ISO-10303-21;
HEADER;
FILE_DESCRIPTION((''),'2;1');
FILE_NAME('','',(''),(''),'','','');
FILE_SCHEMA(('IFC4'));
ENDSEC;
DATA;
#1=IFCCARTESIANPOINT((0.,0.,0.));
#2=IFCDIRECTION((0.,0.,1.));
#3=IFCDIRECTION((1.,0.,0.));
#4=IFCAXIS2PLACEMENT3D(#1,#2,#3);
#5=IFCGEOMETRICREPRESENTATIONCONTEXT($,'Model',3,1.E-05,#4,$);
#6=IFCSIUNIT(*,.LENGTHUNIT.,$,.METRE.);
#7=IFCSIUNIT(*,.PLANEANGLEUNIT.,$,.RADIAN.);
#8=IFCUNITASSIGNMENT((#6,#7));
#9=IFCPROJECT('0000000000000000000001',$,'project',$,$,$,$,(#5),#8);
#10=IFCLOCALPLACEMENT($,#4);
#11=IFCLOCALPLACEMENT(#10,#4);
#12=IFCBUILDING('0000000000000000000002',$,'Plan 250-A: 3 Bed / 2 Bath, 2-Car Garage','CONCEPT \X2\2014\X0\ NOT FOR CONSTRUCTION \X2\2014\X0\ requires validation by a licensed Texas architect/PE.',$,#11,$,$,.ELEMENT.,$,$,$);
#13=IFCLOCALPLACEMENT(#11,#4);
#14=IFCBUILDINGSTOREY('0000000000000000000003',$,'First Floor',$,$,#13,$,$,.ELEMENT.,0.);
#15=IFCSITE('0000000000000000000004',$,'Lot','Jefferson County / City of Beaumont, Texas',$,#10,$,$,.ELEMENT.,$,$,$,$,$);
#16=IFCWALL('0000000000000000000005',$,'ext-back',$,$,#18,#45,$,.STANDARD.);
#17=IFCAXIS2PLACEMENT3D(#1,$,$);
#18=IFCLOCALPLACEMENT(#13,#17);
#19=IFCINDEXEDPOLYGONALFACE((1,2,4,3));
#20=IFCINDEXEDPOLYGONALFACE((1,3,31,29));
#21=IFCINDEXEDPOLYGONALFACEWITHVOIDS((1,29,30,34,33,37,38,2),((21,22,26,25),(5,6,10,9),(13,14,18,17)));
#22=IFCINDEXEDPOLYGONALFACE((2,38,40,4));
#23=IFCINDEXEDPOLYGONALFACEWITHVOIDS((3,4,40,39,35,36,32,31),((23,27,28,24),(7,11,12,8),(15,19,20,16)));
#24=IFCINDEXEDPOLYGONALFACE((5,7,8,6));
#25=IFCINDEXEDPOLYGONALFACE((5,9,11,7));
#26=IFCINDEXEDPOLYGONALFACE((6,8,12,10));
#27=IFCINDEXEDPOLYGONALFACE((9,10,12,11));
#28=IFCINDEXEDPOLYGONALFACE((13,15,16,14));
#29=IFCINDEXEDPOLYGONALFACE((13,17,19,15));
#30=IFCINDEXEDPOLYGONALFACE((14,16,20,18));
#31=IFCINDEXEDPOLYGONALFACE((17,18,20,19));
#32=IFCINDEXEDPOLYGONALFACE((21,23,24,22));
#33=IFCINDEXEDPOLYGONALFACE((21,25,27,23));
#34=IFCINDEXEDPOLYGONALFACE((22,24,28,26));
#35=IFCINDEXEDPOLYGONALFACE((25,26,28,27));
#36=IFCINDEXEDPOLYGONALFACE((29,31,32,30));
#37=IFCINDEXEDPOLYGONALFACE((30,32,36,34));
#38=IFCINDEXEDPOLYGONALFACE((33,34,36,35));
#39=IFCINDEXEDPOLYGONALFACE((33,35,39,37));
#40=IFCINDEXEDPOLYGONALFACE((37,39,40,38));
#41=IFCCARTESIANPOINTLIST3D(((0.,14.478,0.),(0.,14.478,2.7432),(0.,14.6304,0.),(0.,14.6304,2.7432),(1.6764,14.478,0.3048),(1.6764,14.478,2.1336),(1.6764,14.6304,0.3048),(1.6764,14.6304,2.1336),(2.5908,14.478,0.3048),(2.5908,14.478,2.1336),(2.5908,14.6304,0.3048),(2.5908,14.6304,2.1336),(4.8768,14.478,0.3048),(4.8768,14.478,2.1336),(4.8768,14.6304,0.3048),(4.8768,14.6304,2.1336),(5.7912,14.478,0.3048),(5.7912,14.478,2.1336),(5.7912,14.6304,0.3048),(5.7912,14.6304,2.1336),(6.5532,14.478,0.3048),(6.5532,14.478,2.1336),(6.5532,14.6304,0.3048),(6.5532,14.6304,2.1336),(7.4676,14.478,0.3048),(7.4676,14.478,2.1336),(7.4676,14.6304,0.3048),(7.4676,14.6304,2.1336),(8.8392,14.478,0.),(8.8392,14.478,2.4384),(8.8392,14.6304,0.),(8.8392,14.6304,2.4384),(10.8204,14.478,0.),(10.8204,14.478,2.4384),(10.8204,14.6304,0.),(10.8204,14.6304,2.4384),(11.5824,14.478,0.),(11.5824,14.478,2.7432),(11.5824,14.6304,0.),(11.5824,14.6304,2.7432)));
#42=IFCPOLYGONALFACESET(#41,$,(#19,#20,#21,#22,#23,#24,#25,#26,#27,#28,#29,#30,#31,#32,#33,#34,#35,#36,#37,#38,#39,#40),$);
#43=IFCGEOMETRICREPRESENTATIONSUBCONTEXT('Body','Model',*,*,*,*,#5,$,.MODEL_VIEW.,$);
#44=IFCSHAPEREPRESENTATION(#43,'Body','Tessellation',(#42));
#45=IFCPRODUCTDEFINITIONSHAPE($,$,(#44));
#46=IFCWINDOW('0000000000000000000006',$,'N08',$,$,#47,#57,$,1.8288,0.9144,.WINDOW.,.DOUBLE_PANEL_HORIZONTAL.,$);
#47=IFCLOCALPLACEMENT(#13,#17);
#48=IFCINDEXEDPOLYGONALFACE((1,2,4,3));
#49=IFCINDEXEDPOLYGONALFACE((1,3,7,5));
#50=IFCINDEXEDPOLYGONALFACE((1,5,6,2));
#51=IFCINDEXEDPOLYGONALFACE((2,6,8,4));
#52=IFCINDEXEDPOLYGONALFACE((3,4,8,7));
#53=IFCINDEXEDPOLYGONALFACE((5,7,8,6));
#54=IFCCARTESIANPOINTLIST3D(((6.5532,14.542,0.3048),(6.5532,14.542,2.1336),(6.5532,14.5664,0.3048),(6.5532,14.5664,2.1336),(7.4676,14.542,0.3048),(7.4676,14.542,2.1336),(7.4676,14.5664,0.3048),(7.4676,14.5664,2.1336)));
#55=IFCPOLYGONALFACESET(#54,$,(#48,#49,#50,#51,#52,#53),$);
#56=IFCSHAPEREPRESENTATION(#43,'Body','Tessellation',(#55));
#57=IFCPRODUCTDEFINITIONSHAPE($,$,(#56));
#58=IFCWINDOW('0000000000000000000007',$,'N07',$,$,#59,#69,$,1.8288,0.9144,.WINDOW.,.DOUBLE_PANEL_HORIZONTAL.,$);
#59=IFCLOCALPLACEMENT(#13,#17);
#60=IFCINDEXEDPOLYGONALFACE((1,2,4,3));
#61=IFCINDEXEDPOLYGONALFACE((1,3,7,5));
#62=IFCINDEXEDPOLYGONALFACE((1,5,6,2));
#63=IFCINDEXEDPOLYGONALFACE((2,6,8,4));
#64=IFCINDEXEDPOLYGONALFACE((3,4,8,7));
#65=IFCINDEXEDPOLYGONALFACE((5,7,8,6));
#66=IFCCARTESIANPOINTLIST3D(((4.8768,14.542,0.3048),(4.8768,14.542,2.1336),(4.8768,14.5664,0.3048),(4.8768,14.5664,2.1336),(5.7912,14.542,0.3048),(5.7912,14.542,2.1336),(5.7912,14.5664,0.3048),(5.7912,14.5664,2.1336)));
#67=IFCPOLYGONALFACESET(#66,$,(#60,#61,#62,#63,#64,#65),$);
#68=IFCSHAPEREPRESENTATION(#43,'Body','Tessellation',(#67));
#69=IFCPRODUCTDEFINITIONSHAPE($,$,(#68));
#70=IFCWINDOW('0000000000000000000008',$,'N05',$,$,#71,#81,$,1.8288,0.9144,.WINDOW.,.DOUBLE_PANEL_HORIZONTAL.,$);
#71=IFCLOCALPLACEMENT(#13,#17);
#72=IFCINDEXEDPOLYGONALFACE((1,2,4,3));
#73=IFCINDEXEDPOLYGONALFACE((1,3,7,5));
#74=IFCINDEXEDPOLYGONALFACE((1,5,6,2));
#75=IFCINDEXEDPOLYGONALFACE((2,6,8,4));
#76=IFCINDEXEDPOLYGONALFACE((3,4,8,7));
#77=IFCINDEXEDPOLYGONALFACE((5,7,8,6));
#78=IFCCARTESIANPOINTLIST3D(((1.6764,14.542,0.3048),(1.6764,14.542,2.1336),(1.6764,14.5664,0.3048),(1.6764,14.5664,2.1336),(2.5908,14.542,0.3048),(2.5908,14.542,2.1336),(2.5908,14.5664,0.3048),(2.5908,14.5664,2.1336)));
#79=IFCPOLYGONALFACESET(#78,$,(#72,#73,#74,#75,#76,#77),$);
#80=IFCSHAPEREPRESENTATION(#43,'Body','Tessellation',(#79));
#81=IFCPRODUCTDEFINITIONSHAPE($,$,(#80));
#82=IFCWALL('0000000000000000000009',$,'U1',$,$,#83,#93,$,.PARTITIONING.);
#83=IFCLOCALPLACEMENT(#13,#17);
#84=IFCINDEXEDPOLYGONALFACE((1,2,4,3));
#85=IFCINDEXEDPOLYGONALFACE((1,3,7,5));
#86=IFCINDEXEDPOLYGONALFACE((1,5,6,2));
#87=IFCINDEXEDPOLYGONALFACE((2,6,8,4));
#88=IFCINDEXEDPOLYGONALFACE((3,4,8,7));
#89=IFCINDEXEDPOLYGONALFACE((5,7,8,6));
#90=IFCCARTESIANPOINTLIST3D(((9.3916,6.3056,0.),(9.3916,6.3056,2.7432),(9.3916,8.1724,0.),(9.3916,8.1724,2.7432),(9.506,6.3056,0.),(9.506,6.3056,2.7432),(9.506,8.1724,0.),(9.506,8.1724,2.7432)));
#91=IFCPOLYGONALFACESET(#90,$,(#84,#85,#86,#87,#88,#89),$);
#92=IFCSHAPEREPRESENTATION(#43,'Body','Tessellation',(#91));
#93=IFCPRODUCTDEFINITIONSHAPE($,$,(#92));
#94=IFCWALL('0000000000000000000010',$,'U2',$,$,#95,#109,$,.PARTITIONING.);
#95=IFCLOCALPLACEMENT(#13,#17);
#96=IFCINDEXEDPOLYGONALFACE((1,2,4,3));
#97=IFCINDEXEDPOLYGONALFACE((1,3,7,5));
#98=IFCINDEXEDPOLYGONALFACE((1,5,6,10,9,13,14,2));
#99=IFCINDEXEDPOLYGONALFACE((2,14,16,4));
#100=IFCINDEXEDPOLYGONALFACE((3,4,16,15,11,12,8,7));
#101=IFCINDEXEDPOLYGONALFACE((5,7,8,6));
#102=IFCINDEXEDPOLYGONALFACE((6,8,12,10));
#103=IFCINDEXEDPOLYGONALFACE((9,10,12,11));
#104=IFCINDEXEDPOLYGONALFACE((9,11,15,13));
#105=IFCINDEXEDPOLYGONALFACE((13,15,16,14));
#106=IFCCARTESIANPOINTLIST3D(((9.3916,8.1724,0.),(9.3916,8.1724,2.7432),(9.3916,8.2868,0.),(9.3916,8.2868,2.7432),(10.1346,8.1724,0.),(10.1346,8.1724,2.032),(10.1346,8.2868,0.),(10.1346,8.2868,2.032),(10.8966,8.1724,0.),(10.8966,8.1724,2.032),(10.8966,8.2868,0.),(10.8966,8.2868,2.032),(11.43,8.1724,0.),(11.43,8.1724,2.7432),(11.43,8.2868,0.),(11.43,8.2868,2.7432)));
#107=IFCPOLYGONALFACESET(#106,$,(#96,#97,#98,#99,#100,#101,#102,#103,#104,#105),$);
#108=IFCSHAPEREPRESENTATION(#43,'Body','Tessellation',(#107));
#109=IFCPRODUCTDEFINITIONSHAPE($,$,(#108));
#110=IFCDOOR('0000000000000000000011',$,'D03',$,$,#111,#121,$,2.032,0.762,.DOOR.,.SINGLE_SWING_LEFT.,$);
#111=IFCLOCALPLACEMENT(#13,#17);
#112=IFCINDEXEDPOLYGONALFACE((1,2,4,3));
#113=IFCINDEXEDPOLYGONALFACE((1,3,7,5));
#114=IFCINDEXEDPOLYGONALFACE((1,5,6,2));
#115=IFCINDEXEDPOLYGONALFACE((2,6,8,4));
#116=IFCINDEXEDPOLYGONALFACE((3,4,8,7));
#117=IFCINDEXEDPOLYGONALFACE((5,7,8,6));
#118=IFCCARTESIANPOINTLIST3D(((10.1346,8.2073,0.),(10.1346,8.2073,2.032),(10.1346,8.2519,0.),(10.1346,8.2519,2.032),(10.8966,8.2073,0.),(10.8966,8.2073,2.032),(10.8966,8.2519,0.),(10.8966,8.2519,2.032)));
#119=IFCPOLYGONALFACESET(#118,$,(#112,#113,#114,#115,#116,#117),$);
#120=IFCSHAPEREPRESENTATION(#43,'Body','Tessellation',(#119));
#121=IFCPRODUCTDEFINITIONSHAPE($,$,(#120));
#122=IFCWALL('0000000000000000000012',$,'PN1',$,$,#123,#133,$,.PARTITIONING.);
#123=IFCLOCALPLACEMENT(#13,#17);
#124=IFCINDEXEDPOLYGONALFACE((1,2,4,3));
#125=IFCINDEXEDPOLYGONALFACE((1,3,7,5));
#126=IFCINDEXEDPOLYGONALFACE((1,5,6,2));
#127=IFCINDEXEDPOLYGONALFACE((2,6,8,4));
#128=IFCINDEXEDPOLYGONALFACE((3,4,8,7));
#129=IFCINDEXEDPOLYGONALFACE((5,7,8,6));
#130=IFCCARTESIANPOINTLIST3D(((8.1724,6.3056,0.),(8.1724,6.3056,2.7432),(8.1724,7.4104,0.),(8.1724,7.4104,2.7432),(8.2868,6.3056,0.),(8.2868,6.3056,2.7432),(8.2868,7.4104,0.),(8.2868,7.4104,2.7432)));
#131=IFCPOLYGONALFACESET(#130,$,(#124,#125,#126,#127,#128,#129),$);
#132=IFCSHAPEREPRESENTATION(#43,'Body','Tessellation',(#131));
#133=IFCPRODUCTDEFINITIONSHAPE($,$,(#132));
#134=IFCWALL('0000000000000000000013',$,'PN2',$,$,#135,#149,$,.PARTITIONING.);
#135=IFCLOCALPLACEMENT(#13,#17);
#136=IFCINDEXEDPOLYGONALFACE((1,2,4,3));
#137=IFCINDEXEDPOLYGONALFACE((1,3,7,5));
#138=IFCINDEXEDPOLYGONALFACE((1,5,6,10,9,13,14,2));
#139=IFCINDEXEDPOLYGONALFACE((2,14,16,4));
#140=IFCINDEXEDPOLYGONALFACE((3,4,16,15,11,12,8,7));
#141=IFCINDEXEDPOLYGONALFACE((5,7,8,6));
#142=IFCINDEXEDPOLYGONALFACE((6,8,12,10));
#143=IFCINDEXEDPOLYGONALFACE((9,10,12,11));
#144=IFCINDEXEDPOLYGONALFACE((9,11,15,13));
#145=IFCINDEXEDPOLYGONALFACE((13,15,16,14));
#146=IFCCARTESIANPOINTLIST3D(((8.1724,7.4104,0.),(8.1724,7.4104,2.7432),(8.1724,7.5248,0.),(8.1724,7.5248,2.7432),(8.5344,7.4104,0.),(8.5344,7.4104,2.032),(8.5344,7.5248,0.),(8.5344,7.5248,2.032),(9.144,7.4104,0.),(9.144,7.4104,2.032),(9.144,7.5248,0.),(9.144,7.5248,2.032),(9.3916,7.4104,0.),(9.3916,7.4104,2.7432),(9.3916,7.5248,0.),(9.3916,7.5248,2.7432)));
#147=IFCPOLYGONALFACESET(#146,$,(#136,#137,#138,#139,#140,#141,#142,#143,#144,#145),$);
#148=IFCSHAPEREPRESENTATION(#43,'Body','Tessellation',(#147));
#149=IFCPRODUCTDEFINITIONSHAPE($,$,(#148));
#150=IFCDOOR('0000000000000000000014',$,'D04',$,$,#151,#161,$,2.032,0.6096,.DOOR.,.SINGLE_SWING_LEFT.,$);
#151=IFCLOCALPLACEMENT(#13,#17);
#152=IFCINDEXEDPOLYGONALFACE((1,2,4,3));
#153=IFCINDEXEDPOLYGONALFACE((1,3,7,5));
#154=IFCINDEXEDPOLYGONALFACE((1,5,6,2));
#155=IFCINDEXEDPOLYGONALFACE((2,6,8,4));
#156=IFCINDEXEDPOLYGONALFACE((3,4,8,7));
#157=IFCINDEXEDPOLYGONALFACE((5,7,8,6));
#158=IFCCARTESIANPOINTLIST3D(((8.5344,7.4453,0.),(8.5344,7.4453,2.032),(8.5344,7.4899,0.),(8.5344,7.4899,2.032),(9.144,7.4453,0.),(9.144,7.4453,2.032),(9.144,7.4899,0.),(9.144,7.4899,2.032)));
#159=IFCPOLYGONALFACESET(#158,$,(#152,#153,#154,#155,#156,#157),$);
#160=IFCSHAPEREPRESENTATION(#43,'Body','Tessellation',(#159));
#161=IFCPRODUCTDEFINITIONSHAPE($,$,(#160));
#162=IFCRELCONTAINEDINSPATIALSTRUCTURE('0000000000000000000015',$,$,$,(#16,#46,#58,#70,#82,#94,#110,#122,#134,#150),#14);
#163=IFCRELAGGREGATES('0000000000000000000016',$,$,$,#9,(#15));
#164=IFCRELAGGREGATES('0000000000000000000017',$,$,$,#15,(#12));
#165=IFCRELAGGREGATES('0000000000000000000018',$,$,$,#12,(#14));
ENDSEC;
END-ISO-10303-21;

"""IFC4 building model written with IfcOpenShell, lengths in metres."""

from ifc_helpers import new_model, si_unit, frame, frame_2d, origin_with_axes, place, context, subcontext, project, spatial, rectangle, extrude, element, fill, save


model = new_model("IFC4")

# Units and contexts
model_context = context("Model", 3, precision=1e-05, world=origin_with_axes())
body_context = subcontext(model_context, "Body", "Model", "MODEL_VIEW")
ifc_project = project(units=[si_unit("LENGTHUNIT", "METRE"), si_unit("PLANEANGLEUNIT", "RADIAN")], contexts=[model_context])

# Site, building, storey
site_placement = place(None, origin_with_axes())
site = spatial("IfcSite", under=ifc_project, at=site_placement, Name="Lot", Description="Jefferson County / City of Beaumont, Texas", CompositionType="ELEMENT")
building_placement = place(site_placement, origin_with_axes())
building = spatial("IfcBuilding", under=site, at=building_placement, Name="Plan 250-A: 3 Bed / 2 Bath, 2-Car Garage", Description="CONCEPT — NOT FOR CONSTRUCTION — requires validation by a licensed Texas architect/PE.", CompositionType="ELEMENT")
storey_placement = place(building_placement, origin_with_axes())
storey = spatial("IfcBuildingStorey", under=building, at=storey_placement, Name="First Floor", CompositionType="ELEMENT", Elevation=0.0)

# Wall, openings, windows
wall_1_placement = place(storey_placement, frame((11.5824, 14.5542, 0.0), z_axis=(0.0, 0.0, 1.0), x_axis=(-1.0, 0.0, 0.0)))
wall_1 = element("IfcWall", 1, at=wall_1_placement, inside=storey, Name="ext-back", PredefinedType="STANDARD", context=body_context, shape_type="SweptSolid", body=[
    extrude(rectangle(XDim=11.5824, YDim=0.1524, at=frame_2d((5.7912, 0.0), x_axis=(1.0, 0.0))), origin_with_axes(), (0.0, 0.0, 1.0), 2.7432),
])
opening_1_placement = place(wall_1_placement, frame((0.762, 0.0, 0.0), z_axis=(0.0, 0.0, 1.0), x_axis=(1.0, 0.0, 0.0)))
element("IfcOpeningElement", 2, at=opening_1_placement, cuts=wall_1, PredefinedType="OPENING", context=body_context, shape_type="SweptSolid", body=[
    extrude(rectangle(XDim=1.9812, YDim=0.1829, at=frame_2d((0.9906, 0.0), x_axis=(1.0, 0.0))), origin_with_axes(), (0.0, 0.0, 1.0), 2.4384),
])
opening_2_placement = place(wall_1_placement, frame((4.1148, 0.0, 0.3048), z_axis=(0.0, 0.0, 1.0), x_axis=(1.0, 0.0, 0.0)))
opening_2 = element("IfcOpeningElement", 3, at=opening_2_placement, cuts=wall_1, PredefinedType="OPENING", context=body_context, shape_type="SweptSolid", body=[
    extrude(rectangle(XDim=0.9144, YDim=0.1829, at=frame_2d((0.4572, 0.0), x_axis=(1.0, 0.0))), origin_with_axes(), (0.0, 0.0, 1.0), 1.8288),
])
opening_3_placement = place(wall_1_placement, frame((5.7912, 0.0, 0.3048), z_axis=(0.0, 0.0, 1.0), x_axis=(1.0, 0.0, 0.0)))
opening_3 = element("IfcOpeningElement", 4, at=opening_3_placement, cuts=wall_1, PredefinedType="OPENING", context=body_context, shape_type="SweptSolid", body=[
    extrude(rectangle(XDim=0.9144, YDim=0.1829, at=frame_2d((0.4572, 0.0), x_axis=(1.0, 0.0))), origin_with_axes(), (0.0, 0.0, 1.0), 1.8288),
])
opening_4_placement = place(wall_1_placement, frame((8.9916, 0.0, 0.3048), z_axis=(0.0, 0.0, 1.0), x_axis=(1.0, 0.0, 0.0)))
opening_4 = element("IfcOpeningElement", 5, at=opening_4_placement, cuts=wall_1, PredefinedType="OPENING", context=body_context, shape_type="SweptSolid", body=[
    extrude(rectangle(XDim=0.9144, YDim=0.1829, at=frame_2d((0.4572, 0.0), x_axis=(1.0, 0.0))), origin_with_axes(), (0.0, 0.0, 1.0), 1.8288),
])
window_1_placement = place(opening_2_placement, origin_with_axes())
window_1 = element("IfcWindow", 6, at=window_1_placement, inside=storey, Name="N08", OverallHeight=1.8288, OverallWidth=0.9144, PartitioningType="DOUBLE_PANEL_HORIZONTAL", PredefinedType="WINDOW", context=body_context, shape_type="SweptSolid", body=[
    extrude(rectangle(XDim=0.9144, YDim=0.0244, at=frame_2d((0.4572, 0.0), x_axis=(1.0, 0.0))), origin_with_axes(), (0.0, 0.0, 1.0), 1.8288),
])
fill(opening_2, window_1)
window_2_placement = place(opening_3_placement, origin_with_axes())
window_2 = element("IfcWindow", 7, at=window_2_placement, inside=storey, Name="N07", OverallHeight=1.8288, OverallWidth=0.9144, PartitioningType="DOUBLE_PANEL_HORIZONTAL", PredefinedType="WINDOW", context=body_context, shape_type="SweptSolid", body=[
    extrude(rectangle(XDim=0.9144, YDim=0.0244, at=frame_2d((0.4572, 0.0), x_axis=(1.0, 0.0))), origin_with_axes(), (0.0, 0.0, 1.0), 1.8288),
])
fill(opening_3, window_2)
window_3_placement = place(opening_4_placement, origin_with_axes())
window_3 = element("IfcWindow", 8, at=window_3_placement, inside=storey, Name="N05", OverallHeight=1.8288, OverallWidth=0.9144, PartitioningType="DOUBLE_PANEL_HORIZONTAL", PredefinedType="WINDOW", context=body_context, shape_type="SweptSolid", body=[
    extrude(rectangle(XDim=0.9144, YDim=0.0244, at=frame_2d((0.4572, 0.0), x_axis=(1.0, 0.0))), origin_with_axes(), (0.0, 0.0, 1.0), 1.8288),
])
fill(opening_4, window_3)

# Wall
wall_2_placement = place(storey_placement, frame((9.4488, 6.3056, 0.0), z_axis=(0.0, 0.0, 1.0), x_axis=(0.0, 1.0, 0.0)))
element("IfcWall", 9, at=wall_2_placement, inside=storey, Name="U1", PredefinedType="PARTITIONING", context=body_context, shape_type="SweptSolid", body=[
    extrude(rectangle(XDim=1.8669, YDim=0.1143, at=frame_2d((0.9335, 0.0), x_axis=(1.0, 0.0))), origin_with_axes(), (0.0, 0.0, 1.0), 2.7432),
])

# Wall, opening, door
wall_3_placement = place(storey_placement, frame((9.3917, 8.2296, 0.0), z_axis=(0.0, 0.0, 1.0), x_axis=(1.0, 0.0, 0.0)))
wall_3 = element("IfcWall", 10, at=wall_3_placement, inside=storey, Name="U2", PredefinedType="PARTITIONING", context=body_context, shape_type="SweptSolid", body=[
    extrude(rectangle(XDim=2.0383, YDim=0.1143, at=frame_2d((1.0192, 0.0), x_axis=(1.0, 0.0))), origin_with_axes(), (0.0, 0.0, 1.0), 2.7432),
])
opening_5_placement = place(wall_3_placement, frame((0.7429, 0.0, 0.0), z_axis=(0.0, 0.0, 1.0), x_axis=(1.0, 0.0, 0.0)))
opening_5 = element("IfcOpeningElement", 11, at=opening_5_placement, cuts=wall_3, PredefinedType="OPENING", context=body_context, shape_type="SweptSolid", body=[
    extrude(rectangle(XDim=0.762, YDim=0.1448, at=frame_2d((0.381, 0.0), x_axis=(1.0, 0.0))), origin_with_axes(), (0.0, 0.0, 1.0), 2.032),
])
door_1_placement = place(opening_5_placement, origin_with_axes())
door_1 = element("IfcDoor", 12, at=door_1_placement, inside=storey, Name="D03", OperationType="SINGLE_SWING_LEFT", OverallHeight=2.032, OverallWidth=0.762, PredefinedType="DOOR", context=body_context, shape_type="SweptSolid", body=[
    extrude(rectangle(XDim=0.762, YDim=0.0445, at=frame_2d((0.381, 0.0), x_axis=(1.0, 0.0))), origin_with_axes(), (0.0, 0.0, 1.0), 2.032),
])
fill(opening_5, door_1)

# Wall
wall_4_placement = place(storey_placement, frame((8.2296, 6.3056, 0.0), z_axis=(0.0, 0.0, 1.0), x_axis=(0.0, 1.0, 0.0)))
element("IfcWall", 13, at=wall_4_placement, inside=storey, Name="PN1", PredefinedType="PARTITIONING", context=body_context, shape_type="SweptSolid", body=[
    extrude(rectangle(XDim=1.1049, YDim=0.1143, at=frame_2d((0.5524, 0.0), x_axis=(1.0, 0.0))), origin_with_axes(), (0.0, 0.0, 1.0), 2.7432),
])

# Wall, opening, door
wall_5_placement = place(storey_placement, frame((8.1724, 7.4676, 0.0), z_axis=(0.0, 0.0, 1.0), x_axis=(1.0, 0.0, 0.0)))
wall_5 = element("IfcWall", 14, at=wall_5_placement, inside=storey, Name="PN2", PredefinedType="PARTITIONING", context=body_context, shape_type="SweptSolid", body=[
    extrude(rectangle(XDim=1.2192, YDim=0.1143, at=frame_2d((0.6096, 0.0), x_axis=(1.0, 0.0))), origin_with_axes(), (0.0, 0.0, 1.0), 2.7432),
])
opening_6_placement = place(wall_5_placement, frame((0.3619, 0.0, 0.0), z_axis=(0.0, 0.0, 1.0), x_axis=(1.0, 0.0, 0.0)))
opening_6 = element("IfcOpeningElement", 15, at=opening_6_placement, cuts=wall_5, PredefinedType="OPENING", context=body_context, shape_type="SweptSolid", body=[
    extrude(rectangle(XDim=0.6096, YDim=0.1448, at=frame_2d((0.3048, 0.0), x_axis=(1.0, 0.0))), origin_with_axes(), (0.0, 0.0, 1.0), 2.032),
])
door_2_placement = place(opening_6_placement, origin_with_axes())
door_2 = element("IfcDoor", 16, at=door_2_placement, inside=storey, Name="D04", OperationType="SINGLE_SWING_LEFT", OverallHeight=2.032, OverallWidth=0.6096, PredefinedType="DOOR", context=body_context, shape_type="SweptSolid", body=[
    extrude(rectangle(XDim=0.6096, YDim=0.0445, at=frame_2d((0.3048, 0.0), x_axis=(1.0, 0.0))), origin_with_axes(), (0.0, 0.0, 1.0), 2.032),
])
fill(opening_6, door_2)

save(model, "model.ifc")
